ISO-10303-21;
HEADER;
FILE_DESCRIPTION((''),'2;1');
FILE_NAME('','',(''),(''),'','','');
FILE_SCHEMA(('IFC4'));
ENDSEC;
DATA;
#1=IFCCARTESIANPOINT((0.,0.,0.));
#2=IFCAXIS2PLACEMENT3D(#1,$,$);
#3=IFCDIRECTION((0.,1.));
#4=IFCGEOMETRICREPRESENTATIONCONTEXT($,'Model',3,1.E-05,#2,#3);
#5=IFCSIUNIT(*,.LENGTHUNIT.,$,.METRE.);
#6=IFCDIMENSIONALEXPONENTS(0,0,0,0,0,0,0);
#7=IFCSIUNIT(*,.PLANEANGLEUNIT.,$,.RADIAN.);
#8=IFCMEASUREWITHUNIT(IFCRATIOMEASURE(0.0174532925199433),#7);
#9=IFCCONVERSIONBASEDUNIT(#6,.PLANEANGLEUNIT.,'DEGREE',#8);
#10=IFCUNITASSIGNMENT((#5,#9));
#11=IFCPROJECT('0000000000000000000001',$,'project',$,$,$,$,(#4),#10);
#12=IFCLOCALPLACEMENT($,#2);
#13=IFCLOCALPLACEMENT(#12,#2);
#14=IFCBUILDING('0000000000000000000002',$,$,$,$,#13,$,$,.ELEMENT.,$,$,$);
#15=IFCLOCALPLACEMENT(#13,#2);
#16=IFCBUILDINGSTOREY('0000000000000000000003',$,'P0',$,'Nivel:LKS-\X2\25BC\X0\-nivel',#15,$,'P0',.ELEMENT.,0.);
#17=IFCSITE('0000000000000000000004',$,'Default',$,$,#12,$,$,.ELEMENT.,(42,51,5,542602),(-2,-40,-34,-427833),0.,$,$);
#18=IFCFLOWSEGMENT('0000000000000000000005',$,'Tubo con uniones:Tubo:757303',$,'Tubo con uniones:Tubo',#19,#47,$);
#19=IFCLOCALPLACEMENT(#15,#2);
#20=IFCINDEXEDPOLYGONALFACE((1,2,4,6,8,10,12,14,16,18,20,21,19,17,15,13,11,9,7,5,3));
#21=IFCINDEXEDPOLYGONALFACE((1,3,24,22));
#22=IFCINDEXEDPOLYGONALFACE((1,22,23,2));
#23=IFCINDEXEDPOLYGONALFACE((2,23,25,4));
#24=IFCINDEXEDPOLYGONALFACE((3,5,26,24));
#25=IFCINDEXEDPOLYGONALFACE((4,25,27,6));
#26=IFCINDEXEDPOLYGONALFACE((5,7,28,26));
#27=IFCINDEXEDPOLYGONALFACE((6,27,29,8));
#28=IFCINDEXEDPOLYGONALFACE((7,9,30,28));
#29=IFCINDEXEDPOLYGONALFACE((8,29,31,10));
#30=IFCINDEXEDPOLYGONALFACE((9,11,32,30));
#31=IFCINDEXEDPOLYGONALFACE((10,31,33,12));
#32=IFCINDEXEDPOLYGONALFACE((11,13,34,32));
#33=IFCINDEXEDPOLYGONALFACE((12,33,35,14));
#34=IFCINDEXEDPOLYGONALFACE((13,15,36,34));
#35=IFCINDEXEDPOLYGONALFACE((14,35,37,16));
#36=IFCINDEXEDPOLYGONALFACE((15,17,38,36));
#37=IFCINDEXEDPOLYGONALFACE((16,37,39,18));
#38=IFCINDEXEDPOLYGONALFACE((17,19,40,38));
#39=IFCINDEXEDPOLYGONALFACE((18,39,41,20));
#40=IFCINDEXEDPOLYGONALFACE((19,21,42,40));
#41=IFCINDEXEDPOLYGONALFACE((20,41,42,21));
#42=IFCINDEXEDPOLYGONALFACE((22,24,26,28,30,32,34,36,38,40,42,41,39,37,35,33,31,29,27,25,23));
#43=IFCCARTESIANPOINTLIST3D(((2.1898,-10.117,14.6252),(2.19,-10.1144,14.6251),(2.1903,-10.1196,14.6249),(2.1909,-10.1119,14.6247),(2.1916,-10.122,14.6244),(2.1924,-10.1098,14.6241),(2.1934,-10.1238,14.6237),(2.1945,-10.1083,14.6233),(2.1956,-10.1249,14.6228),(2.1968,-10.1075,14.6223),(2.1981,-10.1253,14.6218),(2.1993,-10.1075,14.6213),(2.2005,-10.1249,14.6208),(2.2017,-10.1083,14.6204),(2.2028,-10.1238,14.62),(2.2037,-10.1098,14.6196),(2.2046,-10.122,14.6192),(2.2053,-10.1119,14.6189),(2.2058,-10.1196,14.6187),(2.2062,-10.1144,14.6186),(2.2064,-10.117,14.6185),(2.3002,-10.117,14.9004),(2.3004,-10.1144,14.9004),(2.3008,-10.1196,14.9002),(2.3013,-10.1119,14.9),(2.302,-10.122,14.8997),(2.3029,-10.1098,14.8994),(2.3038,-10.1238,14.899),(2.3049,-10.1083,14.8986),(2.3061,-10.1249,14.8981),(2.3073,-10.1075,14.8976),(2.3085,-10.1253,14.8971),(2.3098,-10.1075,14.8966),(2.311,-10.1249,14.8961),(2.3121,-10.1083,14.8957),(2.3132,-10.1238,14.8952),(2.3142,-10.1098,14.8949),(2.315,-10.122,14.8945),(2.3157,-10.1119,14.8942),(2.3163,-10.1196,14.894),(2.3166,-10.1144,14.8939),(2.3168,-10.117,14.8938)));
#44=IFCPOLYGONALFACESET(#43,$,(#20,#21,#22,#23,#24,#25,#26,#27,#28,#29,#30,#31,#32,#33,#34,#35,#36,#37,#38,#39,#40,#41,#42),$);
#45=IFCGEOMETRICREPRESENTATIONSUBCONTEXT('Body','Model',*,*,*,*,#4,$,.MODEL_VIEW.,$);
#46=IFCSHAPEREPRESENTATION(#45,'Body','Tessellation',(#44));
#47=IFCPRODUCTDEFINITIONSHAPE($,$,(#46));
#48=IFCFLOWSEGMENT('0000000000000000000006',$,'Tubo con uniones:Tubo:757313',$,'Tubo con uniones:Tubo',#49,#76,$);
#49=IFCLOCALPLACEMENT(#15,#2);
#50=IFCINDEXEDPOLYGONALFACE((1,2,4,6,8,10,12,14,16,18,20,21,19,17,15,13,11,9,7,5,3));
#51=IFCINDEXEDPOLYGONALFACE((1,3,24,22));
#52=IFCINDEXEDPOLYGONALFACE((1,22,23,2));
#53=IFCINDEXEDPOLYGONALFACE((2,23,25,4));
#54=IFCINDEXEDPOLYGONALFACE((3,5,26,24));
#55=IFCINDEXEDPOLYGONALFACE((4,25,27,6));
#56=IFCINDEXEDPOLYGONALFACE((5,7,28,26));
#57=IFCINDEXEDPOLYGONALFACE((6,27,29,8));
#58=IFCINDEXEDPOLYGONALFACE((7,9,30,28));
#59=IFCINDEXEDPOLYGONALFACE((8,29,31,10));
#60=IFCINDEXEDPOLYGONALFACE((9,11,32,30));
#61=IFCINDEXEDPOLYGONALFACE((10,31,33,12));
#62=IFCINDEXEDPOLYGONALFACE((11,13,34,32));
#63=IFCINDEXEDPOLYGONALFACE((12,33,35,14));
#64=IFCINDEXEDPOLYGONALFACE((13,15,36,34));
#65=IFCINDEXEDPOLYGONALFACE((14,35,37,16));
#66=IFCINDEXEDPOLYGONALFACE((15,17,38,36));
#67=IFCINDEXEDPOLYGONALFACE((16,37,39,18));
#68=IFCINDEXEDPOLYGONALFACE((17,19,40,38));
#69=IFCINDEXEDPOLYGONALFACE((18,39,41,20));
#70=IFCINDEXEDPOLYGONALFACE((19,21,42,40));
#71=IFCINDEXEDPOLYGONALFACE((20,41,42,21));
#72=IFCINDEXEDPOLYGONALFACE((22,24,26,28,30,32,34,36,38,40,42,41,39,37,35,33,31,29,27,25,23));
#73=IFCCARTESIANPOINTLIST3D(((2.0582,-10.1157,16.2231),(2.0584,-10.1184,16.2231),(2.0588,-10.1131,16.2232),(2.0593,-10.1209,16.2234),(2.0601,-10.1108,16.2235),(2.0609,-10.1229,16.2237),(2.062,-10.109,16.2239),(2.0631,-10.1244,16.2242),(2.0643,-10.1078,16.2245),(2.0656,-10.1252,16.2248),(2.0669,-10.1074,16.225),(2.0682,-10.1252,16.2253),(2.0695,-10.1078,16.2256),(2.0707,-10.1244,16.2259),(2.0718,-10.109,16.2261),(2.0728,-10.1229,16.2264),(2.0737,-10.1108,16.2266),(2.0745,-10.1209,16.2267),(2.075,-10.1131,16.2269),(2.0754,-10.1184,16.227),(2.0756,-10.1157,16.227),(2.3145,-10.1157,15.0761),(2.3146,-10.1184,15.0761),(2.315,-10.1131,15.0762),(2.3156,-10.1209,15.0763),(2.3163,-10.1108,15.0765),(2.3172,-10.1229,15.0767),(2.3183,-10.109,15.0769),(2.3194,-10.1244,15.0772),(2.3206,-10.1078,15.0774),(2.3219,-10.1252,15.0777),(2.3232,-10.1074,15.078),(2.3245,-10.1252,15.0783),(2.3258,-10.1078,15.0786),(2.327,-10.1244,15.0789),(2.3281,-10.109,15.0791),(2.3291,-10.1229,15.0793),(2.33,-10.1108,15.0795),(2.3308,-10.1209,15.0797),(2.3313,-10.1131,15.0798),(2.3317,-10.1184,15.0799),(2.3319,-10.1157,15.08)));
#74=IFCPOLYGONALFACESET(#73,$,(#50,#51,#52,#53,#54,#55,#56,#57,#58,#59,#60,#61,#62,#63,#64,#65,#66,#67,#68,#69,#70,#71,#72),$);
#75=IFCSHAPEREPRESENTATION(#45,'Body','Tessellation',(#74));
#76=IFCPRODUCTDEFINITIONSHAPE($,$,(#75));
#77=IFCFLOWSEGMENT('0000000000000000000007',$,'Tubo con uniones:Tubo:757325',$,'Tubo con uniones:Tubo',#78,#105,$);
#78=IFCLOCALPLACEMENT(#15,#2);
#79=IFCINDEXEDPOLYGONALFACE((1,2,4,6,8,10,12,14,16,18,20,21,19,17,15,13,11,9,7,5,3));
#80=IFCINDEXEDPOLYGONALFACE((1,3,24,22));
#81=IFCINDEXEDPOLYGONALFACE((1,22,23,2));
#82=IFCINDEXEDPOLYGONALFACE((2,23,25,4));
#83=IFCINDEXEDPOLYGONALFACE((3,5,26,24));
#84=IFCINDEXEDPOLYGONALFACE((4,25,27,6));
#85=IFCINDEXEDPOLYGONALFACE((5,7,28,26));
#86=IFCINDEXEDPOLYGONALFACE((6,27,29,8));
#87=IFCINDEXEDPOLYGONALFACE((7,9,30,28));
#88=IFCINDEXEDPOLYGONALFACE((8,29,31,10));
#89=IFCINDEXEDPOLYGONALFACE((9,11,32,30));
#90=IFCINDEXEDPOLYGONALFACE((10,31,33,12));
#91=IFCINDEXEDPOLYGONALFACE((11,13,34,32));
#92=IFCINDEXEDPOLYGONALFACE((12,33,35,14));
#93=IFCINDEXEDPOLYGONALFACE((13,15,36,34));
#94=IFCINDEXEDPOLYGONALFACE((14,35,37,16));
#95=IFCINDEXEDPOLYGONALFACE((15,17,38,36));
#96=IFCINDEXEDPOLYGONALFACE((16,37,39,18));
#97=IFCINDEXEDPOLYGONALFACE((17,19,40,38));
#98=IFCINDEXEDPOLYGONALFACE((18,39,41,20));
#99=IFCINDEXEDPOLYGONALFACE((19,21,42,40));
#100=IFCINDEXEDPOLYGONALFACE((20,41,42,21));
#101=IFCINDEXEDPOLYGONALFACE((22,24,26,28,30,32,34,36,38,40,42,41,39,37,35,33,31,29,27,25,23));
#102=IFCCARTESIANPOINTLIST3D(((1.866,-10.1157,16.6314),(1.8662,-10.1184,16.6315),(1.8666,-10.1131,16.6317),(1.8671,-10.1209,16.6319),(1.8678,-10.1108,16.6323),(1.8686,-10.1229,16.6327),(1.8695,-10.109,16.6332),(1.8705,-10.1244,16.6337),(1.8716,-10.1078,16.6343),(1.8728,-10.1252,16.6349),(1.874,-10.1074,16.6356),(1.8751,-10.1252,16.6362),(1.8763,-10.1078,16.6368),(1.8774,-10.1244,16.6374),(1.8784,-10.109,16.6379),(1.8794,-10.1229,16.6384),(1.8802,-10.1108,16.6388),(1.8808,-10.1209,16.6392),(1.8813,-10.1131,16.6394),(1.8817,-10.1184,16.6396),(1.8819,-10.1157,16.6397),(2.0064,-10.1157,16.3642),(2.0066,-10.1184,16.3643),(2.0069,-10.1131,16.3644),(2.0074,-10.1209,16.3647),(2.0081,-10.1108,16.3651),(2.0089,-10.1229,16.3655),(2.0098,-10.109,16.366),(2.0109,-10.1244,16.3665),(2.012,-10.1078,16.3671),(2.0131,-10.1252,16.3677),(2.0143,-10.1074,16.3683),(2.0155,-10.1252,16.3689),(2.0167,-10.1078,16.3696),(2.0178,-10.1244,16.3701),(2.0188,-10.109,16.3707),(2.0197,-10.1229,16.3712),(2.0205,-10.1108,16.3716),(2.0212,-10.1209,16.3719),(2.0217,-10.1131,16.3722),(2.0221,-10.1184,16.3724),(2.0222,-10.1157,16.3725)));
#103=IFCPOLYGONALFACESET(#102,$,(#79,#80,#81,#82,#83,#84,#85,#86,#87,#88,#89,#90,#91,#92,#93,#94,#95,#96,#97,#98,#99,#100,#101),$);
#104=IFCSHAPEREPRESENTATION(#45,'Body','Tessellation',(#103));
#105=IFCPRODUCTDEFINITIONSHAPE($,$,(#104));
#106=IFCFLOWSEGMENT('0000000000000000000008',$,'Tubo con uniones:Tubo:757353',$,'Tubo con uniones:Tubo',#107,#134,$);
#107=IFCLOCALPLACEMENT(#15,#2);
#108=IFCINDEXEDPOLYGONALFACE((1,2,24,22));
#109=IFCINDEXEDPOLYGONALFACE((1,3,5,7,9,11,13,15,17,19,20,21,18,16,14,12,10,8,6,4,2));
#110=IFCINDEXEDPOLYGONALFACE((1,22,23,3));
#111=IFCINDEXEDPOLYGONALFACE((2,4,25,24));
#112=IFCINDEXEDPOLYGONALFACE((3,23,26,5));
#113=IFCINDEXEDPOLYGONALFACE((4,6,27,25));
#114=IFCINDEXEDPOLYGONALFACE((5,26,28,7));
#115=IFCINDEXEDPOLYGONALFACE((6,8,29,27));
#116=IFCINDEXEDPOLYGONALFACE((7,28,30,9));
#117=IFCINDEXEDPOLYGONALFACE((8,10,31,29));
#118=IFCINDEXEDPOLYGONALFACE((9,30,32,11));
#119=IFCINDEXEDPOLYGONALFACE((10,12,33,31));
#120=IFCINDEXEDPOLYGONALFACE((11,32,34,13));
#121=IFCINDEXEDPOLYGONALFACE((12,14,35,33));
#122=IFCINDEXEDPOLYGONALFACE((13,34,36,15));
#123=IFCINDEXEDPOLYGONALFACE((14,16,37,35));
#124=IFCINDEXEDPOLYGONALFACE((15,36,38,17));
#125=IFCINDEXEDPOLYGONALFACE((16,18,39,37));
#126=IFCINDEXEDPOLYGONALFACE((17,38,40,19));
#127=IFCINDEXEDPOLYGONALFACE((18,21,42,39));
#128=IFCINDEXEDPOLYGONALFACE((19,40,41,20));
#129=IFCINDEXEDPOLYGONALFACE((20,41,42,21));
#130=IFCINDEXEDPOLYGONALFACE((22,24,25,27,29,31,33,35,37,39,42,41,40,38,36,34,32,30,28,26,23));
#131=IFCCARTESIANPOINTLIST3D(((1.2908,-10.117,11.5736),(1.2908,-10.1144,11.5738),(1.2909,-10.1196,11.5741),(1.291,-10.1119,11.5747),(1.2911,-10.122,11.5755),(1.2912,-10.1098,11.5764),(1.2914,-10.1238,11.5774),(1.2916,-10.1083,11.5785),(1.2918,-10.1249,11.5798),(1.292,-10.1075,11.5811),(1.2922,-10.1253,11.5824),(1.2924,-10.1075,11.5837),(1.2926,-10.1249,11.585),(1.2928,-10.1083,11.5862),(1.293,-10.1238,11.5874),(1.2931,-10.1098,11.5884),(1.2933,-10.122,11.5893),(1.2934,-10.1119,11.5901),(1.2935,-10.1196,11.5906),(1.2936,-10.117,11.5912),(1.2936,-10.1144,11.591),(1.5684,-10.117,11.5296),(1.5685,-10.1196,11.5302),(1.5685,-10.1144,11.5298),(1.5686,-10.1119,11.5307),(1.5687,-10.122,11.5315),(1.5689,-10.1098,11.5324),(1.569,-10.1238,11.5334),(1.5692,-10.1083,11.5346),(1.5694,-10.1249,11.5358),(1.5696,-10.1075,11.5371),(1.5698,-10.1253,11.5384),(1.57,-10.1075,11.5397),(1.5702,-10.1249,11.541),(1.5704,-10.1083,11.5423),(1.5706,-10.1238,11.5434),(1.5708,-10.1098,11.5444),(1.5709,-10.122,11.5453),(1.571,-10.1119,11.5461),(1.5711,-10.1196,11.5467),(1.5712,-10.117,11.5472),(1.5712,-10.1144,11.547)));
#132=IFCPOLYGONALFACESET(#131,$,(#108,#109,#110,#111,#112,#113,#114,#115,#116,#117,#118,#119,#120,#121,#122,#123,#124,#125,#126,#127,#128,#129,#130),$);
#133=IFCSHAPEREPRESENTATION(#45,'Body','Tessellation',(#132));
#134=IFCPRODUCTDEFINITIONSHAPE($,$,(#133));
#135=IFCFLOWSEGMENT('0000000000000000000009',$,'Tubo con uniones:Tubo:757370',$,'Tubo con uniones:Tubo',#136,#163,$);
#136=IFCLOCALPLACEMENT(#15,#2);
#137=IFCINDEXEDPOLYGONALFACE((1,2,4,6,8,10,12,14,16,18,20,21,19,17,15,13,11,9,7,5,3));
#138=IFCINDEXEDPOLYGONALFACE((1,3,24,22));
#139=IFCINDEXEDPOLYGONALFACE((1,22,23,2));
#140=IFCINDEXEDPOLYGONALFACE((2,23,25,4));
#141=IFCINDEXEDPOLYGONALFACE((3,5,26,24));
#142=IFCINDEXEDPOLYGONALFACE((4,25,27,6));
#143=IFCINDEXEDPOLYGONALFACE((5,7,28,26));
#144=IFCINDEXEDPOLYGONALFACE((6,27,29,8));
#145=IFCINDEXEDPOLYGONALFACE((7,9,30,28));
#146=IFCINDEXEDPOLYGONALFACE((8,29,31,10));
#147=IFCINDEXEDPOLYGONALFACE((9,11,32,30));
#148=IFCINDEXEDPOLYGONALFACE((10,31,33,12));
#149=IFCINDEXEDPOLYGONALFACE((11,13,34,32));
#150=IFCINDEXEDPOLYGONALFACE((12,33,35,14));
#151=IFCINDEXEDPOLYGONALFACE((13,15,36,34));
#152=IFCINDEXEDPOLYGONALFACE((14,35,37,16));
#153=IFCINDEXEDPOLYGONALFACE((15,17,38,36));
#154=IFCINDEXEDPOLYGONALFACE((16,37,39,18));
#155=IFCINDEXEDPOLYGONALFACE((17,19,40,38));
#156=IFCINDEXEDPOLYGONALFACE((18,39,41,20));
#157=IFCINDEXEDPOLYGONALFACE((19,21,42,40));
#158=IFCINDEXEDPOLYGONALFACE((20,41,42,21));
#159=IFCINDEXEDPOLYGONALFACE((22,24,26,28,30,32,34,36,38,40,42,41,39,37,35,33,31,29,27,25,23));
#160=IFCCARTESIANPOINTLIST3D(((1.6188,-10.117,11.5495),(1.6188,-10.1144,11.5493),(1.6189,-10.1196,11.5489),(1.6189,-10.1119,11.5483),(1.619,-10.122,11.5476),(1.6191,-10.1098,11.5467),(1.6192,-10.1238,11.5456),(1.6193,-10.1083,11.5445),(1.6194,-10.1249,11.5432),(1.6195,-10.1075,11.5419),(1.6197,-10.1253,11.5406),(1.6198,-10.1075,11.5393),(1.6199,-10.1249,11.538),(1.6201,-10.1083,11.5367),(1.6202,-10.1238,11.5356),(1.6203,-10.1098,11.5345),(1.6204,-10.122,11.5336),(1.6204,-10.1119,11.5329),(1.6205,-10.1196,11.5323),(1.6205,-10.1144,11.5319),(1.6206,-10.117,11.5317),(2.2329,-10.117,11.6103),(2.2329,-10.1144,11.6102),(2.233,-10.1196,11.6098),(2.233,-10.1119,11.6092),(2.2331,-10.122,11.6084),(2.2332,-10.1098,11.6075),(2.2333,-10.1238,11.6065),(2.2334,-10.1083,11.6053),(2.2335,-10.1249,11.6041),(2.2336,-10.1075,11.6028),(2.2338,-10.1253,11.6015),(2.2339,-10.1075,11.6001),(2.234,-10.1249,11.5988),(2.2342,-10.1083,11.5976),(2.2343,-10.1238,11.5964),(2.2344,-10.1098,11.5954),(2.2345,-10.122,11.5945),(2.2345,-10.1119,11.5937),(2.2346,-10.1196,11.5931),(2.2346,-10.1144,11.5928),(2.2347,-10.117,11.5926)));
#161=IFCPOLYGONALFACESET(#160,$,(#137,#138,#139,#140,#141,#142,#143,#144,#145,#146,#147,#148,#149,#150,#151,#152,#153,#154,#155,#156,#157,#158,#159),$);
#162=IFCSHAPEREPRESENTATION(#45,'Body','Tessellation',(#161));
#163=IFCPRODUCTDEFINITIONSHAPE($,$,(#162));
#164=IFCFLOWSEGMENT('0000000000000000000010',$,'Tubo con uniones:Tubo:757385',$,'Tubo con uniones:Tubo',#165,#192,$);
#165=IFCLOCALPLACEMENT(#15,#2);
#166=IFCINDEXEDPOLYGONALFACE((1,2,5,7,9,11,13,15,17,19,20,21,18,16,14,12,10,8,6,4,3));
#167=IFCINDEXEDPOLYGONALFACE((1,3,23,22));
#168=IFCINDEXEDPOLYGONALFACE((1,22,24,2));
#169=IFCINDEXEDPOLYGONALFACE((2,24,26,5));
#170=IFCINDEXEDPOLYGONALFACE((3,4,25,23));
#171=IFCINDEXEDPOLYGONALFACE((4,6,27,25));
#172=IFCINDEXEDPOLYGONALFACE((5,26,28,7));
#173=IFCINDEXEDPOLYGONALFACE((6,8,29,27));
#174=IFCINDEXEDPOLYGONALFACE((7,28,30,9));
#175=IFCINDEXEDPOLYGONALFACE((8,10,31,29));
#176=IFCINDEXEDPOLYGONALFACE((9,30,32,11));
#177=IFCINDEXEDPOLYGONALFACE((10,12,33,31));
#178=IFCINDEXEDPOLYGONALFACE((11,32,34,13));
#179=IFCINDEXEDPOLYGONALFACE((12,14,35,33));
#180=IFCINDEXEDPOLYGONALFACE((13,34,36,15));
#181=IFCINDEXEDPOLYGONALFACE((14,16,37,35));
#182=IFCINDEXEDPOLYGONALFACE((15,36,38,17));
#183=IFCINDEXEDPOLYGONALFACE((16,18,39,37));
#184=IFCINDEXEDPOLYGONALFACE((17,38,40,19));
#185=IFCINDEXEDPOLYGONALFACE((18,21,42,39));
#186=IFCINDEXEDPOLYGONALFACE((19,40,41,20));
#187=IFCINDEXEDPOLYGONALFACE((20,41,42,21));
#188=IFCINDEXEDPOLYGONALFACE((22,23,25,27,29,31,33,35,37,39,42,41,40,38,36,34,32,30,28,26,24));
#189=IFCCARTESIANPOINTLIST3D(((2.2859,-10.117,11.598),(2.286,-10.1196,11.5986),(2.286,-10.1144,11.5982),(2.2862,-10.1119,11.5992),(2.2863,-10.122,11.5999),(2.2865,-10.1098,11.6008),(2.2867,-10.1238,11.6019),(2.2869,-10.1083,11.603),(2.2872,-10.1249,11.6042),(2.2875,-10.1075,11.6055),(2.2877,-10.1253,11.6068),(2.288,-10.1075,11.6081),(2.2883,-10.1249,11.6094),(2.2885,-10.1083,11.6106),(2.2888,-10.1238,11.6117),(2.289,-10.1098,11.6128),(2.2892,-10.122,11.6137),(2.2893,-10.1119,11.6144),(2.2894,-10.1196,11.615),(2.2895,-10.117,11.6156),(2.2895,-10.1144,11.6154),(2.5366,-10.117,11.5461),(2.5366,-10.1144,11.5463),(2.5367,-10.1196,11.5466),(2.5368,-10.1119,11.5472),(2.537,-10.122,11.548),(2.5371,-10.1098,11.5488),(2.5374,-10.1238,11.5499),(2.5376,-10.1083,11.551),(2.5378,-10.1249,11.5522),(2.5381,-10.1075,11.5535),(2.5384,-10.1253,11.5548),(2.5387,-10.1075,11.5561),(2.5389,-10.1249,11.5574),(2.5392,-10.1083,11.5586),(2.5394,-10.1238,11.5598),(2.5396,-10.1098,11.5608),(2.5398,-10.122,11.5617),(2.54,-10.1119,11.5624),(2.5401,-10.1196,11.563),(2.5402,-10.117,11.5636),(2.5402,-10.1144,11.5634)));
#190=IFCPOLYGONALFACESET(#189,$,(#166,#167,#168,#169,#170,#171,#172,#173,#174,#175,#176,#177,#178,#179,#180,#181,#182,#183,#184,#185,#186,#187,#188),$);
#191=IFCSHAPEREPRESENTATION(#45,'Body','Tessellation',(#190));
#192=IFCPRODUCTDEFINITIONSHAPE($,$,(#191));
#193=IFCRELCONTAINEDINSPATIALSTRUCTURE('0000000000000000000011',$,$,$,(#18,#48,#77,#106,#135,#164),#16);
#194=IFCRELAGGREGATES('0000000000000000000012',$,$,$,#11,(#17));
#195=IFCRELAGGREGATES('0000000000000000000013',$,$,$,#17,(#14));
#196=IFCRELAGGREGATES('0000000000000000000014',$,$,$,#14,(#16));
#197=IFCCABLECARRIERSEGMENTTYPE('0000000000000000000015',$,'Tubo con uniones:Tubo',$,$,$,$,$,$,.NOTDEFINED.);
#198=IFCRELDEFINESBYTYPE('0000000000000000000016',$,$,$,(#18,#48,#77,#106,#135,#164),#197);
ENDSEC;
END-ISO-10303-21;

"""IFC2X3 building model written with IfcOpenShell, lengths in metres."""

from ifc_helpers import new_model, entity, si_unit, converted_unit, direction, frame, frame_2d, origin, origin_2d_with_axis, place, context, subcontext, project, spatial, circle, extrude, type_object, element, save


model = new_model("IFC2X3")

# Units and contexts
model_context = context("Model", 3, precision=1e-05, world=origin(), true_north=direction((0.0, 1.0)))
body_context = subcontext(model_context, "Body", "Model", "MODEL_VIEW")
ifc_project = project(units=[si_unit("LENGTHUNIT", "METRE"), converted_unit("PLANEANGLEUNIT", "DEGREE", entity("IfcRatioMeasure", 0.0174532925199433), si_unit("PLANEANGLEUNIT", "RADIAN"), dimensions=[0, 0, 0, 0, 0, 0, 0])], contexts=[model_context])

# Site, building, storey
site_placement = place(None, origin())
site = spatial("IfcSite", under=ifc_project, at=site_placement, Name="Default", CompositionType="ELEMENT", RefLatitude=(42, 51, 5, 542602), RefLongitude=(-2, -40, -34, -427833), RefElevation=0.0)
building_placement = place(site_placement, origin())
building = spatial("IfcBuilding", under=site, at=building_placement, CompositionType="ELEMENT")
storey_placement = place(building_placement, origin())
storey = spatial("IfcBuildingStorey", under=building, at=storey_placement, Name="P0", ObjectType="Nivel:LKS-▼-nivel", LongName="P0", CompositionType="ELEMENT", Elevation=0.0)

# Flow segments
cable_carrier_segment_type = type_object("IfcCableCarrierSegmentType", Name="Tubo con uniones:Tubo", PredefinedType="NOTDEFINED")
flow_segment_1_placement = place(storey_placement, origin())
element("IfcFlowSegment", 1, at=flow_segment_1_placement, inside=storey, type_object=cable_carrier_segment_type, Name="Tubo con uniones:Tubo:757303", ObjectType="Tubo con uniones:Tubo", context=body_context, shape_type="SweptSolid", body=[
    extrude(circle(Radius=0.009, at=origin_2d_with_axis()), frame((2.1981, -10.1164, 14.6218), z_axis=(0.372325, 0.0, 0.928102), x_axis=(0.0, -1.0, 0.0)), (0.0, 0.0, 1.0), 0.2966),
])
flow_segment_2_placement = place(storey_placement, origin())
element("IfcFlowSegment", 2, at=flow_segment_2_placement, inside=storey, type_object=cable_carrier_segment_type, Name="Tubo con uniones:Tubo:757313", ObjectType="Tubo con uniones:Tubo", context=body_context, shape_type="SweptSolid", body=[
    extrude(circle(Radius=0.009, at=origin_2d_with_axis()), frame((2.0669, -10.1164, 16.225), z_axis=(0.218052, 0.0, -0.975937), x_axis=(0.0, 1.0, 0.0)), (0.0, 0.0, 1.0), 1.1753),
])
flow_segment_3_placement = place(storey_placement, origin())
element("IfcFlowSegment", 3, at=flow_segment_3_placement, inside=storey, type_object=cable_carrier_segment_type, Name="Tubo con uniones:Tubo:757325", ObjectType="Tubo con uniones:Tubo", context=body_context, shape_type="SweptSolid", body=[
    extrude(circle(Radius=0.009, at=origin_2d_with_axis()), frame((2.0143, -10.1164, 16.3683), z_axis=(-0.464995, 0.0, 0.885313), x_axis=(0.0, 1.0, 0.0)), (0.0, 0.0, 1.0), 0.3018),
])
flow_segment_4_placement = place(storey_placement, origin())
element("IfcFlowSegment", 4, at=flow_segment_4_placement, inside=storey, type_object=cable_carrier_segment_type, Name="Tubo con uniones:Tubo:757353", ObjectType="Tubo con uniones:Tubo", context=body_context, shape_type="SweptSolid", body=[
    extrude(circle(Radius=0.009, at=frame_2d((0.0, 0.0), x_axis=(1.0, 0.0))), frame((1.2922, -10.1164, 11.5824), z_axis=(0.987688, 0.0, -0.156434), x_axis=(0.0, -1.0, 0.0)), (0.0, 0.0, 1.0), 0.2811),
])
flow_segment_5_placement = place(storey_placement, origin())
element("IfcFlowSegment", 5, at=flow_segment_5_placement, inside=storey, type_object=cable_carrier_segment_type, Name="Tubo con uniones:Tubo:757370", ObjectType="Tubo con uniones:Tubo", context=body_context, shape_type="SweptSolid", body=[
    extrude(circle(Radius=0.009, at=frame_2d((0.0, 0.0), x_axis=(1.0, 0.0))), frame((1.6197, -10.1164, 11.5406), z_axis=(0.995128, 0.0, 0.098592), x_axis=(0.0, -1.0, 0.0)), (0.0, 0.0, 1.0), 0.6171),
])
flow_segment_6_placement = place(storey_placement, origin())
element("IfcFlowSegment", 6, at=flow_segment_6_placement, inside=storey, type_object=cable_carrier_segment_type, Name="Tubo con uniones:Tubo:757385", ObjectType="Tubo con uniones:Tubo", context=body_context, shape_type="SweptSolid", body=[
    extrude(circle(Radius=0.009, at=origin_2d_with_axis()), frame((2.2877, -10.1164, 11.6068), z_axis=(0.979162, 0.0, -0.203079), x_axis=(0.0, -1.0, 0.0)), (0.0, 0.0, 1.0), 0.256),
])

save(model, "model.ifc")
